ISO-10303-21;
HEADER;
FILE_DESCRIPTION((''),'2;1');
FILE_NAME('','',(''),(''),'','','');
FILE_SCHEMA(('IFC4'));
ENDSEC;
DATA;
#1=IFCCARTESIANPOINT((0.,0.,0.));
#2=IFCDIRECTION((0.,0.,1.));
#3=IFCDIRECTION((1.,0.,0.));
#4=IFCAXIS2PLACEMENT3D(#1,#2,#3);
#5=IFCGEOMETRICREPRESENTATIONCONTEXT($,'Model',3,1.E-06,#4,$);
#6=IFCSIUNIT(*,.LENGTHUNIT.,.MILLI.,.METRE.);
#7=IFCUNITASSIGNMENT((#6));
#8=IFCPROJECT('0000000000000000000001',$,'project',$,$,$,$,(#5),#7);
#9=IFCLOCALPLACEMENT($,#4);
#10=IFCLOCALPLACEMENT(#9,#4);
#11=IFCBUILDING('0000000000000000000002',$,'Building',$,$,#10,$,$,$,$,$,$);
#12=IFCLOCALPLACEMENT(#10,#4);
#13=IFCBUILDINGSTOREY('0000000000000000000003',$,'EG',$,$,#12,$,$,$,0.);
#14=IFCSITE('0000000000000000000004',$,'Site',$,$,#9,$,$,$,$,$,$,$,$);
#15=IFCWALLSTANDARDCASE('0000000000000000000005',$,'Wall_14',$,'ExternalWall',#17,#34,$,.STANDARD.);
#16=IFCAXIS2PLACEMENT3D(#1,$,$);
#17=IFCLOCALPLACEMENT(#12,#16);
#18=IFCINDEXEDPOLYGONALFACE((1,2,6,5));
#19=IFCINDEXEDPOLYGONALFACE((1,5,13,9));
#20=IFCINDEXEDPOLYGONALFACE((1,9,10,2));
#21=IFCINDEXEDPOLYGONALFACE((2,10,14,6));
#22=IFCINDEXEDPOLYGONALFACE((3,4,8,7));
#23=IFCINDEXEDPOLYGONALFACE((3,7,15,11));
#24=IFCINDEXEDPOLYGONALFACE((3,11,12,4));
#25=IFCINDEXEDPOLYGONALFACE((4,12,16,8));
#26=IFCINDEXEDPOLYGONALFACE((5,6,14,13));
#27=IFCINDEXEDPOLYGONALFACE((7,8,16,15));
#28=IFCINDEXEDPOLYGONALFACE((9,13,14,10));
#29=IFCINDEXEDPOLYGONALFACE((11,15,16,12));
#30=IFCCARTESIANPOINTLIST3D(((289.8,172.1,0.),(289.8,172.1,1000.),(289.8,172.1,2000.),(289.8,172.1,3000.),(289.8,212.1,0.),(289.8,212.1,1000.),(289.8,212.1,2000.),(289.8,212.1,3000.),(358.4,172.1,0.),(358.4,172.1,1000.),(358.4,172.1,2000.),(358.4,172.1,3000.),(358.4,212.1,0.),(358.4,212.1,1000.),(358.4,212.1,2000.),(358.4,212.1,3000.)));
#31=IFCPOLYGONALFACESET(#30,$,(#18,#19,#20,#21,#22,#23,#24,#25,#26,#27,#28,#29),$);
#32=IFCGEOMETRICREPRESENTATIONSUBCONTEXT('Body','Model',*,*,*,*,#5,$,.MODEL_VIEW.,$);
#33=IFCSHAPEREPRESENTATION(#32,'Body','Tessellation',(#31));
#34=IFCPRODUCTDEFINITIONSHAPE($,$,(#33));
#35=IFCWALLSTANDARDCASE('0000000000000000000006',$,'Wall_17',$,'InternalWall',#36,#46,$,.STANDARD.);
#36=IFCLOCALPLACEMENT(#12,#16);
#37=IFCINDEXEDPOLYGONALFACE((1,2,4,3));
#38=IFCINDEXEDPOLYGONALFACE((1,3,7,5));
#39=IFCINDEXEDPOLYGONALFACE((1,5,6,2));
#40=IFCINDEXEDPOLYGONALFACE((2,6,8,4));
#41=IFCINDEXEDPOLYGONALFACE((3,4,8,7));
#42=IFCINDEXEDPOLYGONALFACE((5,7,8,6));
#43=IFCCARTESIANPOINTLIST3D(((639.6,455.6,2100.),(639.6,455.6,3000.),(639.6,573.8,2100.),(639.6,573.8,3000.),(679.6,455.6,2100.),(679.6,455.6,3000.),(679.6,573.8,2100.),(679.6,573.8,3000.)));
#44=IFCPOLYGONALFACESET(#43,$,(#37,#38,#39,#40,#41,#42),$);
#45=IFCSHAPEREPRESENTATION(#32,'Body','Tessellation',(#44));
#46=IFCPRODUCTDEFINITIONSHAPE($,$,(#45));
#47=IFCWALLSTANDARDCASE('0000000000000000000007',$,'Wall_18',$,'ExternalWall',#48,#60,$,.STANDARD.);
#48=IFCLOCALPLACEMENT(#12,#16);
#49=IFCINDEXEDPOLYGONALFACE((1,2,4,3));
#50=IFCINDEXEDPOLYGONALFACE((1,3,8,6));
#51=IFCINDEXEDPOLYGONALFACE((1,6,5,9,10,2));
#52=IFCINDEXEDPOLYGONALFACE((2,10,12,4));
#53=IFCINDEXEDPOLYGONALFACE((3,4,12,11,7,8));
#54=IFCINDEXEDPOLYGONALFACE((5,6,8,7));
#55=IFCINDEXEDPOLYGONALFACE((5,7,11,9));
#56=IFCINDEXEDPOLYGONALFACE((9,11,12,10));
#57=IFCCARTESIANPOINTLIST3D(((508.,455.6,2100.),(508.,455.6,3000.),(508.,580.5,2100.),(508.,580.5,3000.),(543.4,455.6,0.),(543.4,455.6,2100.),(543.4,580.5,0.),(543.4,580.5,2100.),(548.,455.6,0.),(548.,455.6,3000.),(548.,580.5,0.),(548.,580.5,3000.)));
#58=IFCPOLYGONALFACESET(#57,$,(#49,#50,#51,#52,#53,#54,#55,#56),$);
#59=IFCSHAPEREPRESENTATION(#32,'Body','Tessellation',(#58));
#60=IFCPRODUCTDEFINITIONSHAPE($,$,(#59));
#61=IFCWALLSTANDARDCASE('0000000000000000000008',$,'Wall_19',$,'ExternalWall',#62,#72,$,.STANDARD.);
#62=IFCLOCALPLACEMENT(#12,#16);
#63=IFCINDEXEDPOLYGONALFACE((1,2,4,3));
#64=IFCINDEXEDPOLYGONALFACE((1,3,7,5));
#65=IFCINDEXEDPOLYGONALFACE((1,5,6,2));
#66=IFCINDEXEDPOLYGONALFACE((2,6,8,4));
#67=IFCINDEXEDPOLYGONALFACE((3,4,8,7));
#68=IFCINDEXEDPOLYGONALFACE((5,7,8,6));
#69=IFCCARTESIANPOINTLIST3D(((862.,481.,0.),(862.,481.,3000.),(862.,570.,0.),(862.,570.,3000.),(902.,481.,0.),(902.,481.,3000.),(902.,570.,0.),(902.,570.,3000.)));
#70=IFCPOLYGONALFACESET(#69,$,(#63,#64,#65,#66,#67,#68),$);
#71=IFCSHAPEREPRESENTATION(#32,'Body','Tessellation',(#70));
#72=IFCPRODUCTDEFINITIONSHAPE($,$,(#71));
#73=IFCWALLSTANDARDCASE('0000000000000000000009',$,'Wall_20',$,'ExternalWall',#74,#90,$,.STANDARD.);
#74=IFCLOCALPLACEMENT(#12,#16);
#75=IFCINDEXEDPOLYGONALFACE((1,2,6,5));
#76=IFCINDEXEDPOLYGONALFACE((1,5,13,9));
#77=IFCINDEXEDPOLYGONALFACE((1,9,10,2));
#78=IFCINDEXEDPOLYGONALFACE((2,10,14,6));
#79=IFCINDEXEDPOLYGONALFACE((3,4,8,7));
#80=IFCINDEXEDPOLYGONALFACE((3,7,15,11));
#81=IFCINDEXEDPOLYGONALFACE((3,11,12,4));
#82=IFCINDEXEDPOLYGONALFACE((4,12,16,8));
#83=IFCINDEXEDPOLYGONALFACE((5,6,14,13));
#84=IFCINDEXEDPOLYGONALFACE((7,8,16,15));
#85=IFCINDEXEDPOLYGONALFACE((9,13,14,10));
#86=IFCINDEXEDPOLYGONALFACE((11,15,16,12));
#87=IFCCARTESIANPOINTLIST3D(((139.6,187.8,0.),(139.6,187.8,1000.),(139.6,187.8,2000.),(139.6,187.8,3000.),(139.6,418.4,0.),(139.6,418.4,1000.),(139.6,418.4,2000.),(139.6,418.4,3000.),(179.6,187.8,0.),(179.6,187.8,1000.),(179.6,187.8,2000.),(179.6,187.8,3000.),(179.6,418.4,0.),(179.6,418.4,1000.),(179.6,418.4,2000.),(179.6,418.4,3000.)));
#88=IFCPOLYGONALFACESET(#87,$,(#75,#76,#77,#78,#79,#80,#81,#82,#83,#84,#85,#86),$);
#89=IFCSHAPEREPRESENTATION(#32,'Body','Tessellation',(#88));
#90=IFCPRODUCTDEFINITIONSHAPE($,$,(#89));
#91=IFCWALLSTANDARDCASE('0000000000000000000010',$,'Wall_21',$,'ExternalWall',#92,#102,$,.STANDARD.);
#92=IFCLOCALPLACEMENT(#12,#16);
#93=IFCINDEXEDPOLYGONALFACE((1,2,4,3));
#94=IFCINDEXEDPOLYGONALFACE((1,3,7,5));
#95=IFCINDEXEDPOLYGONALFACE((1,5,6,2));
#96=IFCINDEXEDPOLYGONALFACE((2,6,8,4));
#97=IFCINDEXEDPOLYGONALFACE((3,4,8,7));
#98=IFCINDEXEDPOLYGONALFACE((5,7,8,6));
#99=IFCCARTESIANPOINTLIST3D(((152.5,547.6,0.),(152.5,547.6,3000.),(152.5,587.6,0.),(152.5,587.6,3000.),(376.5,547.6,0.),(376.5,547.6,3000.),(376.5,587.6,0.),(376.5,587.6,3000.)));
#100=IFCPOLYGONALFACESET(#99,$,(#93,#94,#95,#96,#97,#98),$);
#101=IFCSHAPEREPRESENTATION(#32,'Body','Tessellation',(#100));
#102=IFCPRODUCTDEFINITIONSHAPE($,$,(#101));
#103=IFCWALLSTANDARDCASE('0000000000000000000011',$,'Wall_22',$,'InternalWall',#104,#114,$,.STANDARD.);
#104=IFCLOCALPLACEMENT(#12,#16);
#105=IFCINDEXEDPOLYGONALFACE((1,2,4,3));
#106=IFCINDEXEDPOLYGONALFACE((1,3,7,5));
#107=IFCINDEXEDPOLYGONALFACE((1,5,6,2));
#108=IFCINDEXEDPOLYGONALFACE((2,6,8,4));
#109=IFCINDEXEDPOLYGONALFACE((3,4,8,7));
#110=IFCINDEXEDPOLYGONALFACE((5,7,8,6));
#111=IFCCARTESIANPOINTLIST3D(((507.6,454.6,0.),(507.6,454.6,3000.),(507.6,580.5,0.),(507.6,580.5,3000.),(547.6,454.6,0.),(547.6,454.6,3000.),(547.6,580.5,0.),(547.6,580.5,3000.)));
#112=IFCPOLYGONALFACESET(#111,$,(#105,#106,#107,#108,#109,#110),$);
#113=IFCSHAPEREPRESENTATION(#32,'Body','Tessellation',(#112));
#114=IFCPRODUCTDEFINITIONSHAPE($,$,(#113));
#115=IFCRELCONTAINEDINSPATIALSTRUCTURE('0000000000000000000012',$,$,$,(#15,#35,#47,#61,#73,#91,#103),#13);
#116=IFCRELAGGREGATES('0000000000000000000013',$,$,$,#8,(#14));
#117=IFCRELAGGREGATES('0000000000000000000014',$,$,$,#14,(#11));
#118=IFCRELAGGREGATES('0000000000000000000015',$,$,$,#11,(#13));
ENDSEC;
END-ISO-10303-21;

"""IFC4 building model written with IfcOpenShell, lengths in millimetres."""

from ifc_helpers import new_model, si_unit, frame, origin_with_axes, place, context, subcontext, project, spatial, rectangle, extrude, element, save


model = new_model("IFC4")

# Units and contexts
model_context = context("Model", 3, precision=1e-06, world=origin_with_axes())
body_context = subcontext(model_context, "Body", "Model", "MODEL_VIEW")
ifc_project = project(units=[si_unit("LENGTHUNIT", "METRE", prefix="MILLI")], contexts=[model_context])

# Site, building, storey
site_placement = place(None, origin_with_axes())
site = spatial("IfcSite", under=ifc_project, at=site_placement, Name="Site")
building_placement = place(site_placement, origin_with_axes())
building = spatial("IfcBuilding", under=site, at=building_placement, Name="Building")
storey_placement = place(building_placement, origin_with_axes())
storey = spatial("IfcBuildingStorey", under=building, at=storey_placement, Name="EG", Elevation=0.0)

# Wall, opening
wall_1_placement = place(storey_placement, origin_with_axes())
wall_1 = element("IfcWallStandardCase", 1, at=wall_1_placement, inside=storey, Name="Wall_14", ObjectType="ExternalWall", PredefinedType="STANDARD", context=body_context, shape_type="SweptSolid", body=[
    extrude(rectangle(XDim=68.6, YDim=40.0), frame((324.1, 192.1, 0.0), z_axis=(0.0, 0.0, 1.0), x_axis=(-1.0, 0.0, 0.0)), (0.0, 0.0, 1.0), 3000.0),
])
opening_1_placement = place(wall_1_placement, origin_with_axes())
element("IfcOpeningElement", 2, at=opening_1_placement, inside=storey, cuts=wall_1, context=body_context, shape_type="SweptSolid", body=[
    extrude(rectangle(XDim=1200.0, YDim=40.0), frame((383.1, 192.1, 1000.0), z_axis=(0.0, 0.0, 1.0), x_axis=(-1.0, 0.0, 0.0)), (0.0, 0.0, 1.0), 1000.0),
])

# Walls, openings
wall_2_placement = place(storey_placement, origin_with_axes())
wall_2 = element("IfcWallStandardCase", 3, at=wall_2_placement, inside=storey, Name="Wall_17", ObjectType="InternalWall", PredefinedType="STANDARD", context=body_context, shape_type="SweptSolid", body=[
    extrude(rectangle(XDim=118.2, YDim=40.0), frame((659.6, 514.7, 0.0), z_axis=(0.0, 0.0, 1.0), x_axis=(0.0, 1.0, 0.0)), (0.0, 0.0, 1.0), 3000.0),
])
opening_2_placement = place(wall_2_placement, origin_with_axes())
element("IfcOpeningElement", 4, at=opening_2_placement, inside=storey, cuts=wall_2, context=body_context, shape_type="SweptSolid", body=[
    extrude(rectangle(XDim=450.0, YDim=40.0), frame((659.6, 456.1, 0.0), z_axis=(0.0, 0.0, 1.0), x_axis=(0.0, 1.0, 0.0)), (0.0, 0.0, 1.0), 2100.0),
])
wall_3_placement = place(storey_placement, origin_with_axes())
wall_3 = element("IfcWallStandardCase", 5, at=wall_3_placement, inside=storey, Name="Wall_18", ObjectType="ExternalWall", PredefinedType="STANDARD", context=body_context, shape_type="SweptSolid", body=[
    extrude(rectangle(XDim=124.9, YDim=40.0), frame((528.0, 518.0, 0.0), z_axis=(0.0, 0.0, 1.0), x_axis=(0.0, 1.0, 0.0)), (0.0, 0.0, 1.0), 3000.0),
])
opening_3_placement = place(wall_3_placement, origin_with_axes())
element("IfcOpeningElement", 6, at=opening_3_placement, inside=storey, cuts=wall_3, context=body_context, shape_type="SweptSolid", body=[
    extrude(rectangle(XDim=900.0, YDim=40.0), frame((523.4, 438.6, 0.0), z_axis=(0.0, 0.0, 1.0), x_axis=(0.0, 1.0, 0.0)), (0.0, 0.0, 1.0), 2100.0),
])

# Wall
wall_4_placement = place(storey_placement, origin_with_axes())
element("IfcWallStandardCase", 7, at=wall_4_placement, inside=storey, Name="Wall_19", ObjectType="ExternalWall", PredefinedType="STANDARD", context=body_context, shape_type="SweptSolid", body=[
    extrude(rectangle(XDim=89.0, YDim=40.0), frame((882.0, 525.5, 0.0), z_axis=(0.0, 0.0, 1.0), x_axis=(0.0, 1.0, 0.0)), (0.0, 0.0, 1.0), 3000.0),
])

# Wall, opening
wall_5_placement = place(storey_placement, origin_with_axes())
wall_5 = element("IfcWallStandardCase", 8, at=wall_5_placement, inside=storey, Name="Wall_20", ObjectType="ExternalWall", PredefinedType="STANDARD", context=body_context, shape_type="SweptSolid", body=[
    extrude(rectangle(XDim=230.7, YDim=40.0), frame((159.6, 303.1, 0.0), z_axis=(0.0, 0.0, 1.0), x_axis=(0.0, 1.0, 0.0)), (0.0, 0.0, 1.0), 3000.0),
])
opening_4_placement = place(wall_5_placement, origin_with_axes())
element("IfcOpeningElement", 9, at=opening_4_placement, inside=storey, cuts=wall_5, context=body_context, shape_type="SweptSolid", body=[
    extrude(rectangle(XDim=600.0, YDim=40.0), frame((159.6, 192.5, 1000.0), z_axis=(0.0, 0.0, 1.0), x_axis=(0.0, 1.0, 0.0)), (0.0, 0.0, 1.0), 1000.0),
])

# Walls
wall_6_placement = place(storey_placement, origin_with_axes())
element("IfcWallStandardCase", 10, at=wall_6_placement, inside=storey, Name="Wall_21", ObjectType="ExternalWall", PredefinedType="STANDARD", context=body_context, shape_type="SweptSolid", body=[
    extrude(rectangle(XDim=224.0, YDim=40.0), frame((264.5, 567.6, 0.0), z_axis=(0.0, 0.0, 1.0), x_axis=(-1.0, 0.0, 0.0)), (0.0, 0.0, 1.0), 3000.0),
])
wall_7_placement = place(storey_placement, origin_with_axes())
element("IfcWallStandardCase", 11, at=wall_7_placement, inside=storey, Name="Wall_22", ObjectType="InternalWall", PredefinedType="STANDARD", context=body_context, shape_type="SweptSolid", body=[
    extrude(rectangle(XDim=125.8, YDim=40.0), frame((527.6, 517.5, 0.0), z_axis=(0.0, 0.0, 1.0), x_axis=(0.0, 1.0, 0.0)), (0.0, 0.0, 1.0), 3000.0),
])

save(model, "model.ifc")
